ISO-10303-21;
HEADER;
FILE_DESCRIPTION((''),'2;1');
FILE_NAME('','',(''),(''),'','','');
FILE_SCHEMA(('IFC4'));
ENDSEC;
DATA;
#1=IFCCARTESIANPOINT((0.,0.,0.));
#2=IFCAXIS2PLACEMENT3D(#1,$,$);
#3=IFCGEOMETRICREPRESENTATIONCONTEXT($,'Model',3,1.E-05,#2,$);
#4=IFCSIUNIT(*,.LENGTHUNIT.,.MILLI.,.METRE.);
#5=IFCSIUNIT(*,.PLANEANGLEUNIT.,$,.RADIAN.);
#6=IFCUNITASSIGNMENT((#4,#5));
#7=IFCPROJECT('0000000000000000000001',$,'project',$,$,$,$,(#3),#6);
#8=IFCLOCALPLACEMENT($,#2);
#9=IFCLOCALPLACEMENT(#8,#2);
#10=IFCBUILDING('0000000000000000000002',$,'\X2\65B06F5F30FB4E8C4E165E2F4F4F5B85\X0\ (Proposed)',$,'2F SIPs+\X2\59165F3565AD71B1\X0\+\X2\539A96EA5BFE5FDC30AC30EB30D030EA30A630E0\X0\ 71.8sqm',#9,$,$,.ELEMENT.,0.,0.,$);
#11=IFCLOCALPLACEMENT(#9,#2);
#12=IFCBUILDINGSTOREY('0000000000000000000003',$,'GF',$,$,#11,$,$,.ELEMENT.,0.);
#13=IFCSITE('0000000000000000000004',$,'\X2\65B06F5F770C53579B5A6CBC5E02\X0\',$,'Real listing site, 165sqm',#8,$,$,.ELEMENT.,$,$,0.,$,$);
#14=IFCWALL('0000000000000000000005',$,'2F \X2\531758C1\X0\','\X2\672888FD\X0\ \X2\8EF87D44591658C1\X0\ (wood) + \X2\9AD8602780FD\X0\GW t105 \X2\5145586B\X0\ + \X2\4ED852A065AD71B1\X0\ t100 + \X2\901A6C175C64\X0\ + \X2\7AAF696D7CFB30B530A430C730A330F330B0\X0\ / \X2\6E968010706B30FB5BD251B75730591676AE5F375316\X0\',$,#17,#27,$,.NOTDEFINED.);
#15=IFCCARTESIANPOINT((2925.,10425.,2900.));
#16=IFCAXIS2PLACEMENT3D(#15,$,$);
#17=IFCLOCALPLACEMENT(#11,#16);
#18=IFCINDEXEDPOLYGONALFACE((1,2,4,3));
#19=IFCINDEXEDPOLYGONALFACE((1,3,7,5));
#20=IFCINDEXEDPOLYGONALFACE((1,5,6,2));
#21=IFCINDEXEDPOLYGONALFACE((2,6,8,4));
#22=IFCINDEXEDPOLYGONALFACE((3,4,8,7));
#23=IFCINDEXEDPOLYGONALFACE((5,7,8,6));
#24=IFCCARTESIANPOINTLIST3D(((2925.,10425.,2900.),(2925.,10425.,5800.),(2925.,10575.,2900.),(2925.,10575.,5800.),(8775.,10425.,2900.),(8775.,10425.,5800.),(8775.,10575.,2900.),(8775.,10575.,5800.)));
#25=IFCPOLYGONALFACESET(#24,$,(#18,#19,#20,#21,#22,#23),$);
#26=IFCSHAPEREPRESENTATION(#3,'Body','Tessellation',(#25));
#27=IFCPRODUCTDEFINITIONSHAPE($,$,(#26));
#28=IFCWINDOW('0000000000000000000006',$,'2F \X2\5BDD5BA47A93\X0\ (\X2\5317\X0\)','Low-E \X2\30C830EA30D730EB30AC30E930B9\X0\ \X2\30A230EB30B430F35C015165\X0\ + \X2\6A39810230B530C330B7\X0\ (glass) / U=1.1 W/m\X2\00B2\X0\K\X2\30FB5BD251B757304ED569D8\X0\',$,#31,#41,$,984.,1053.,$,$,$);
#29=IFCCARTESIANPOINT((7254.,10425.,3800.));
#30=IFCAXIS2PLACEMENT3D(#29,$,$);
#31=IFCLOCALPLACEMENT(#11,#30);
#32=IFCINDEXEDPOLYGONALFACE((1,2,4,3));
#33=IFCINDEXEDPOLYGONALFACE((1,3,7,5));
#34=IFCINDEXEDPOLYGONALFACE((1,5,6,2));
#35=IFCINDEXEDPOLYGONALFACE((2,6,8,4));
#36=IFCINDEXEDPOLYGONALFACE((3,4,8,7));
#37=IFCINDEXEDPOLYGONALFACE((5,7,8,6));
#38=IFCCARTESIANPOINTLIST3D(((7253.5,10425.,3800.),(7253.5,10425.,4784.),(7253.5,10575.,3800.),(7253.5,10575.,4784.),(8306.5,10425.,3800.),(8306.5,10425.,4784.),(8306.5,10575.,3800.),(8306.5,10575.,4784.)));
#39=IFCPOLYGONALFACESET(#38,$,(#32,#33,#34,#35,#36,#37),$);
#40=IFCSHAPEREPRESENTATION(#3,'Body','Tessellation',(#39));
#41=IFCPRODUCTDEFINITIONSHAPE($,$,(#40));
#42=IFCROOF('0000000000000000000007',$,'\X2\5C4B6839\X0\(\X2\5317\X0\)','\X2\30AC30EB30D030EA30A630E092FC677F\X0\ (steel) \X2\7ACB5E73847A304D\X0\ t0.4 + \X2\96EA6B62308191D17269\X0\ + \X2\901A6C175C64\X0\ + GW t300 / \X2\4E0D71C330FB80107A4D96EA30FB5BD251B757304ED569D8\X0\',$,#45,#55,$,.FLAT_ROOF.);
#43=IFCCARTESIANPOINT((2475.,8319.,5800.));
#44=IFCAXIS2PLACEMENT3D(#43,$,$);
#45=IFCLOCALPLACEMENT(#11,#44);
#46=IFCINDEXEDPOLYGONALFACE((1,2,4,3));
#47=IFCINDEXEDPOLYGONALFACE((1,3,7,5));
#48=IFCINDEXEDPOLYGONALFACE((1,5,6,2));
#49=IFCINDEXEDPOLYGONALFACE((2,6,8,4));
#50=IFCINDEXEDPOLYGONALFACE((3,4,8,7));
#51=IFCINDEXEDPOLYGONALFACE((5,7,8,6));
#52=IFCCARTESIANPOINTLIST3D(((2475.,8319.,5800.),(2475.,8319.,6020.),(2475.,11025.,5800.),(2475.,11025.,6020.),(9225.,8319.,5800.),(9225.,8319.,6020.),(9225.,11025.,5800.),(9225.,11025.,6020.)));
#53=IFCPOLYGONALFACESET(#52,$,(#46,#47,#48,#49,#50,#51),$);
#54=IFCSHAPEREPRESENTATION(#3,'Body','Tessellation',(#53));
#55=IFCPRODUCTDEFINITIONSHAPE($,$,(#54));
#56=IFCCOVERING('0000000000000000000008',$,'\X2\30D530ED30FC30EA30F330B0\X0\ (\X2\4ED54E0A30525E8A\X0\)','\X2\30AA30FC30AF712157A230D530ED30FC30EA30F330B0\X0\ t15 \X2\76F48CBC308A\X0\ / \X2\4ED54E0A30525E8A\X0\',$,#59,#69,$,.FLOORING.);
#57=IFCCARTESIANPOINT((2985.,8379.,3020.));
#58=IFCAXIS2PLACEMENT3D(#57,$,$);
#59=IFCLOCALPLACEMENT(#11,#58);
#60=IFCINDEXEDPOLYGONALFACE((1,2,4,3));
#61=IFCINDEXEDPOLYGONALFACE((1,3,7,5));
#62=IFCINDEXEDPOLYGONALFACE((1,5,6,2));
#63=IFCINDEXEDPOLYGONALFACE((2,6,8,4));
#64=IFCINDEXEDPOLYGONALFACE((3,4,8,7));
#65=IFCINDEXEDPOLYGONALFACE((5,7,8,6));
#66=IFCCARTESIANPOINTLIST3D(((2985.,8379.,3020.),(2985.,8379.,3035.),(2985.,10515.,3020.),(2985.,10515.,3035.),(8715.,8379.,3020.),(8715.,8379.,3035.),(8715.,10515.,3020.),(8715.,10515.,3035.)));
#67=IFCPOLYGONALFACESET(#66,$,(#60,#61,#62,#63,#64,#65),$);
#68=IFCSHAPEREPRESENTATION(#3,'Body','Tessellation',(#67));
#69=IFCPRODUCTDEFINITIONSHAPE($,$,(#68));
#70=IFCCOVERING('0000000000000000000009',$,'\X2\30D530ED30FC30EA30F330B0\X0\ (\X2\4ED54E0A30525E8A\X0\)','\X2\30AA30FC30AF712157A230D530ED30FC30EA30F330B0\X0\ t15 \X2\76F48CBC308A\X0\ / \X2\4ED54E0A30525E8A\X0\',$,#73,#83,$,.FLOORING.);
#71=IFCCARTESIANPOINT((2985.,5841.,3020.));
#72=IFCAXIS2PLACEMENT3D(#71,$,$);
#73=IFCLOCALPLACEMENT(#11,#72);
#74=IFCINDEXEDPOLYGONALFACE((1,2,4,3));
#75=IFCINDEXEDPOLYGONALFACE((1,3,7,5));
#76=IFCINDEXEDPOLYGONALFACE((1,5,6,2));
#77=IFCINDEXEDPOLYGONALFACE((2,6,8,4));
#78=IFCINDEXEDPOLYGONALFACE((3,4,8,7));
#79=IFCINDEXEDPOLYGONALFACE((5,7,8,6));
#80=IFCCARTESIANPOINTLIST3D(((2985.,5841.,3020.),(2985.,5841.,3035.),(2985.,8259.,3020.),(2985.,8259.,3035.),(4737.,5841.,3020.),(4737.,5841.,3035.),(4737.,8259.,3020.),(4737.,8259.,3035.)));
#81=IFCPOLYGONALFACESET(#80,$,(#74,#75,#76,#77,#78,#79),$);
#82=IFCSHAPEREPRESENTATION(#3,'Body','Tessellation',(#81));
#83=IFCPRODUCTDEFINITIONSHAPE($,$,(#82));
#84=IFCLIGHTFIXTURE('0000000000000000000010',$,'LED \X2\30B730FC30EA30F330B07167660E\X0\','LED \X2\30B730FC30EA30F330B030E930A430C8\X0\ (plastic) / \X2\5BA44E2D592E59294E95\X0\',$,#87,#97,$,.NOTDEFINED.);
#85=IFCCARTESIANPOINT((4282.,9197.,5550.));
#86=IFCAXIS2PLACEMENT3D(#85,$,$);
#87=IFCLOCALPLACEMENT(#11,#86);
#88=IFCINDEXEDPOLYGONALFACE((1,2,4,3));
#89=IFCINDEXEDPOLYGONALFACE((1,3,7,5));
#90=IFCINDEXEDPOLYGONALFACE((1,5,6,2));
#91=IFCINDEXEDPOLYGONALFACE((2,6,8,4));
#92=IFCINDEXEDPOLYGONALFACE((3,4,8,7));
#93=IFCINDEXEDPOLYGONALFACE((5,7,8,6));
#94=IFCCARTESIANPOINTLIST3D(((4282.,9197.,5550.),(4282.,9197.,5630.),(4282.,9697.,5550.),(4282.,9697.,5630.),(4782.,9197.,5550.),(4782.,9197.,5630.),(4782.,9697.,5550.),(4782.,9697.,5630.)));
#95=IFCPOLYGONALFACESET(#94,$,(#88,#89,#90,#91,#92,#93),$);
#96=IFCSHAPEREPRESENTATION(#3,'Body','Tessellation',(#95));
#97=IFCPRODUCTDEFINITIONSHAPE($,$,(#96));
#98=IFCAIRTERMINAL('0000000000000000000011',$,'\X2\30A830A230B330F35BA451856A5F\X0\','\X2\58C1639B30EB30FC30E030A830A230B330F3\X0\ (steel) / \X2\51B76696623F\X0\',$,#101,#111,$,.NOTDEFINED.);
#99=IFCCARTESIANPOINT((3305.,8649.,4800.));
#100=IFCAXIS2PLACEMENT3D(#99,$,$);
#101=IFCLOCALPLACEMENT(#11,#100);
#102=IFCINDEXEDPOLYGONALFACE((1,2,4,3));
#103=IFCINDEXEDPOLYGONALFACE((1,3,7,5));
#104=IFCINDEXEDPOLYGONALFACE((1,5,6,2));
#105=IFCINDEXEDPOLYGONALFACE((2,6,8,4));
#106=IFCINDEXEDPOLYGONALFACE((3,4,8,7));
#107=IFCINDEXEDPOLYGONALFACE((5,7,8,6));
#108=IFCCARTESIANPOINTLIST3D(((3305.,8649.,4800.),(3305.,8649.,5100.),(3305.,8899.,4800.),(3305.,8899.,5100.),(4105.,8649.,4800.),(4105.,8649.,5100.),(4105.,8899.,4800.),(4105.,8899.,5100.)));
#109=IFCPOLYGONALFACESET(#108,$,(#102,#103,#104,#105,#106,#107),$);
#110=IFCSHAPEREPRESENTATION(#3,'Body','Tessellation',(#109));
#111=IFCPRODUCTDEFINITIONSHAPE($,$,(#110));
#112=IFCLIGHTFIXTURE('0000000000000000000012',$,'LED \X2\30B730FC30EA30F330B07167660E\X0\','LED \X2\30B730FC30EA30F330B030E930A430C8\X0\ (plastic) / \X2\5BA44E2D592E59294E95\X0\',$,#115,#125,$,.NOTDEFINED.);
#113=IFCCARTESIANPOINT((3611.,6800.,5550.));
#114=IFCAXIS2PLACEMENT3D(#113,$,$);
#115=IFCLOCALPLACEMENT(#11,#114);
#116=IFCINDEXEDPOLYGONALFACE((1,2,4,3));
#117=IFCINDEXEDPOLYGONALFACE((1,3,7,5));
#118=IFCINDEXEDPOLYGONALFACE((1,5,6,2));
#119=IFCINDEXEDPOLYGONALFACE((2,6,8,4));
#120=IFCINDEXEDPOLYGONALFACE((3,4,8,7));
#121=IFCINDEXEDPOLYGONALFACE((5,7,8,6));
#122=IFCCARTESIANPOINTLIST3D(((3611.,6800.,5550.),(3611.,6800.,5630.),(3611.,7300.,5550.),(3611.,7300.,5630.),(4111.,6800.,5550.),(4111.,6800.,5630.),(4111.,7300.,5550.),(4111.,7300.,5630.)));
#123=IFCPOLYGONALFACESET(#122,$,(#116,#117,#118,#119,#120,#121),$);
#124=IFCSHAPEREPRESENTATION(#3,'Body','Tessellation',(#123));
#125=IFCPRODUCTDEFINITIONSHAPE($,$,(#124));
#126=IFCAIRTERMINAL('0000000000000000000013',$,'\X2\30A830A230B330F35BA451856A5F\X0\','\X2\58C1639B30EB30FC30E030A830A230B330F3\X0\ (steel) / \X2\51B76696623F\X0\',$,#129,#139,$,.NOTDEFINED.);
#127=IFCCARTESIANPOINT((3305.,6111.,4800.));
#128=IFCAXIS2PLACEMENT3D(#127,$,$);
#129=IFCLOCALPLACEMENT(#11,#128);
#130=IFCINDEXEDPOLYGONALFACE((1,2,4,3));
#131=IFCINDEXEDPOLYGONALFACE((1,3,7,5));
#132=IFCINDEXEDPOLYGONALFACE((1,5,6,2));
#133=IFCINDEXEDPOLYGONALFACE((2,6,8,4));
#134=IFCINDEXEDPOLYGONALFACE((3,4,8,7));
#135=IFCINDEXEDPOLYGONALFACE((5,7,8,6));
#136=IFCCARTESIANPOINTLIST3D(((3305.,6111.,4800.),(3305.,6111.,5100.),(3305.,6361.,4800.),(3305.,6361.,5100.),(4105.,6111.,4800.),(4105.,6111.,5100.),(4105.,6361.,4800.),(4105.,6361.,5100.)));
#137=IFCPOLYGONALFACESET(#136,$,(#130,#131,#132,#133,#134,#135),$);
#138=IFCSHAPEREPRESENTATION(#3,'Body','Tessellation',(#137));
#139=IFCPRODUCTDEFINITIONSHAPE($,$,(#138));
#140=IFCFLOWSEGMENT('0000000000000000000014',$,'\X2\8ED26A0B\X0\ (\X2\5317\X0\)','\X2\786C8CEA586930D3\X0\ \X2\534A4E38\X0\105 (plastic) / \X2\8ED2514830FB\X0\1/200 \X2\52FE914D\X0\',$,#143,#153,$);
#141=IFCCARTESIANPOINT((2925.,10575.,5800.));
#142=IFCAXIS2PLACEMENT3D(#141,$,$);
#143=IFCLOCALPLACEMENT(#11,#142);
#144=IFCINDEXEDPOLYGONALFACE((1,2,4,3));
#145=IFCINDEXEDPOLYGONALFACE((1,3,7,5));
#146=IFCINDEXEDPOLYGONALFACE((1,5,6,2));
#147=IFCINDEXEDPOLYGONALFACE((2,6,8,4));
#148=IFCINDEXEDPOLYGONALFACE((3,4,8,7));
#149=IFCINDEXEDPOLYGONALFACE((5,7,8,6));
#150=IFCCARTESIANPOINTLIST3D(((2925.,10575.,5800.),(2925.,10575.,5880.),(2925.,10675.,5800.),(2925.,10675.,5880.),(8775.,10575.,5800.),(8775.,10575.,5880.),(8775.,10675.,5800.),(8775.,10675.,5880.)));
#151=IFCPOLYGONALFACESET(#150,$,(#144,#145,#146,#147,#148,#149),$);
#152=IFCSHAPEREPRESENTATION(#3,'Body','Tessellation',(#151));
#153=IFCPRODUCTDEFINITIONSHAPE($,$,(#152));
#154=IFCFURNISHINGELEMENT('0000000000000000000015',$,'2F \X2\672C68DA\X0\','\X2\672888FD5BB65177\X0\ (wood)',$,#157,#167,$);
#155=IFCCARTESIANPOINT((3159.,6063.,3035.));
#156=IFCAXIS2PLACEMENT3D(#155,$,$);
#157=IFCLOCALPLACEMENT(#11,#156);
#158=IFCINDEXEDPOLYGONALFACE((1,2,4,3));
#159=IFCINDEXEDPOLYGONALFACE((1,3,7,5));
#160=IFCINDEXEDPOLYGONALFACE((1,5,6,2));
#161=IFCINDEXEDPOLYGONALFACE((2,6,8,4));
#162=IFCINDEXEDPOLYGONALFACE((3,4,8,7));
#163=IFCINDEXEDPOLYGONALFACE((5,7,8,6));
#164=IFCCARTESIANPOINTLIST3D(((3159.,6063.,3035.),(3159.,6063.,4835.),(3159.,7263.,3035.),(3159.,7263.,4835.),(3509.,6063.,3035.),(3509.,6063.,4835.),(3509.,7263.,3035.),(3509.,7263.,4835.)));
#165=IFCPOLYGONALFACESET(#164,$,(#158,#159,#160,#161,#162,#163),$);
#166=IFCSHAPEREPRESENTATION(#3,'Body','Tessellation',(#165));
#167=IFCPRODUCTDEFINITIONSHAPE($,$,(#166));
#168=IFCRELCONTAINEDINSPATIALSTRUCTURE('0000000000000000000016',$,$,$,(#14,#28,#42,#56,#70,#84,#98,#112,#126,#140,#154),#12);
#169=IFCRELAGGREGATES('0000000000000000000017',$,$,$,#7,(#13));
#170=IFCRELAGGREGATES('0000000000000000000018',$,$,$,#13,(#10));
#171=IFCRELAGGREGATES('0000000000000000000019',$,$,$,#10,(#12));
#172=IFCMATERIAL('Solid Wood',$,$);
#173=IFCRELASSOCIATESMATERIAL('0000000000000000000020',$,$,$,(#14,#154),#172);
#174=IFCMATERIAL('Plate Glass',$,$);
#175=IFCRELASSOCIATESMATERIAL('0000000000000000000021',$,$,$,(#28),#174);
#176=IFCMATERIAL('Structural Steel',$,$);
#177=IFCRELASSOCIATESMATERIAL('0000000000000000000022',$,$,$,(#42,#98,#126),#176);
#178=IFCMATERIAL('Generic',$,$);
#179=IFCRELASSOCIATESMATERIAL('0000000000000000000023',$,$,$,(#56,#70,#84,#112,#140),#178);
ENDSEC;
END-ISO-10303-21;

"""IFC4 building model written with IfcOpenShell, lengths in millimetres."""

from ifc_helpers import new_model, si_unit, frame, frame_2d, origin, place, context, project, spatial, rectangle, extrude, material, element, fill, save


model = new_model("IFC4")

# Units and contexts
model_context = context("Model", 3, precision=1e-05, world=origin())
ifc_project = project(units=[si_unit("LENGTHUNIT", "METRE", prefix="MILLI"), si_unit("PLANEANGLEUNIT", "RADIAN")], contexts=[model_context])

# Site, building, storey
site_placement = place(None, origin())
site = spatial("IfcSite", under=ifc_project, at=site_placement, Name="新潟県南魚沼市", ObjectType="Real listing site, 165sqm", CompositionType="ELEMENT", RefElevation=0.0)
building_placement = place(site_placement, origin())
building = spatial("IfcBuilding", under=site, at=building_placement, Name="新潟・二世帯住宅 (Proposed)", ObjectType="2F SIPs+外張断熱+厚雪対応ガルバリウム 71.8sqm", CompositionType="ELEMENT", ElevationOfRefHeight=0.0, ElevationOfTerrain=0.0)
storey_placement = place(building_placement, origin())
storey = spatial("IfcBuildingStorey", under=building, at=storey_placement, Name="GF", CompositionType="ELEMENT", Elevation=0.0)

# Shared definitions
ifc_material_1 = material(Name="Solid Wood")

# Wall, opening, window
wall_placement = place(storey_placement, frame((2925.0, 10425.0, 2900.0)))
wall = element("IfcWall", 1, at=wall_placement, inside=storey, material=ifc_material_1, Name="2F 北壁", Description="木製 軸組外壁 (wood) + 高性能GW t105 充填 + 付加断熱 t100 + 通気層 + 窯業系サイディング / 準耐火・寒冷地外皮強化", PredefinedType="NOTDEFINED", context=model_context, shape_type="SweptSolid", body=[
    extrude(rectangle(XDim=5850.0, YDim=150.0, at=frame_2d((2925.0, 75.0))), frame((2925.0, 10425.0, 2900.0)), (0.0, 0.0, 1.0), 2900.0),
])
opening_placement = place(storey_placement, frame((7254.0, 10425.0, 3800.0)))
opening = element("IfcOpeningElement", 2, at=opening_placement, cuts=wall, PredefinedType="NOTDEFINED", context=model_context, shape_type="SweptSolid", body=[
    extrude(rectangle(XDim=1053.0, YDim=150.0, at=frame_2d((526.0, 75.0))), frame((7254.0, 10425.0, 3800.0)), (0.0, 0.0, 1.0), 984.0),
])
ifc_material_2 = material(Name="Plate Glass")
window_placement = place(storey_placement, frame((7254.0, 10425.0, 3800.0)))
window = element("IfcWindow", 3, at=window_placement, inside=storey, material=ifc_material_2, Name="2F 寝室窓 (北)", Description="Low-E トリプルガラス アルゴン封入 + 樹脂サッシ (glass) / U=1.1 W/m²K・寒冷地仕様", OverallHeight=984.0, OverallWidth=1053.0, context=model_context, shape_type="SweptSolid", body=[
    extrude(rectangle(XDim=1053.0, YDim=150.0, at=frame_2d((526.0, 75.0))), frame((7254.0, 10425.0, 3800.0)), (0.0, 0.0, 1.0), 984.0),
])
fill(opening, window)

# Roof
ifc_material_3 = material(Name="Structural Steel")
for number, where, name in (
    (4, (2475.0, 8319.0, 5800.0), "屋根(北)"),
):
    element("IfcRoof", number, at=place(storey_placement, frame(where)), inside=storey, material=ifc_material_3, Name=name, Description="ガルバリウム鋼板 (steel) 立平葺き t0.4 + 雪止め金物 + 通気層 + GW t300 / 不燃・耐積雪・寒冷地仕様", PredefinedType="FLAT_ROOF", context=model_context, shape_type="SweptSolid", body=[
        extrude(rectangle(XDim=6750.0, YDim=2706.0, at=frame_2d((3375.0, 1353.0))), frame((2475.0, 8319.0, 5800.0)), (0.0, 0.0, 1.0), 220.0),
    ])

# Coverings
ifc_material_4 = material(Name="Generic")
covering_1_placement = place(storey_placement, frame((2985.0, 8379.0, 3020.0)))
element("IfcCovering", 5, at=covering_1_placement, inside=storey, material=ifc_material_4, Name="フローリング (仕上げ床)", Description="オーク無垢フローリング t15 直貼り / 仕上げ床", PredefinedType="FLOORING", context=model_context, shape_type="SweptSolid", body=[
    extrude(rectangle(XDim=5730.0, YDim=2136.0, at=frame_2d((2865.0, 1068.0))), frame((2985.0, 8379.0, 3020.0)), (0.0, 0.0, 1.0), 15.0),
])
covering_2_placement = place(storey_placement, frame((2985.0, 5841.0, 3020.0)))
element("IfcCovering", 6, at=covering_2_placement, inside=storey, material=ifc_material_4, Name="フローリング (仕上げ床)", Description="オーク無垢フローリング t15 直貼り / 仕上げ床", PredefinedType="FLOORING", context=model_context, shape_type="SweptSolid", body=[
    extrude(rectangle(XDim=1752.0, YDim=2418.0, at=frame_2d((876.0, 1209.0))), frame((2985.0, 5841.0, 3020.0)), (0.0, 0.0, 1.0), 15.0),
])

# Light fixture
light_fixture_1_placement = place(storey_placement, frame((4282.0, 9197.0, 5550.0)))
element("IfcLightFixture", 7, at=light_fixture_1_placement, inside=storey, material=ifc_material_4, Name="LED シーリング照明", Description="LED シーリングライト (plastic) / 室中央天井", PredefinedType="NOTDEFINED", context=model_context, shape_type="SweptSolid", body=[
    extrude(rectangle(XDim=500.0, YDim=500.0, at=frame_2d((250.0, 250.0))), frame((4282.0, 9197.0, 5550.0)), (0.0, 0.0, 1.0), 80.0),
])

# Air terminal
air_terminal_1_placement = place(storey_placement, frame((3305.0, 8649.0, 4800.0)))
element("IfcAirTerminal", 8, at=air_terminal_1_placement, inside=storey, material=ifc_material_3, Name="エアコン室内機", Description="壁掛ルームエアコン (steel) / 冷暖房", PredefinedType="NOTDEFINED", context=model_context, shape_type="SweptSolid", body=[
    extrude(rectangle(XDim=800.0, YDim=250.0, at=frame_2d((400.0, 125.0))), frame((3305.0, 8649.0, 4800.0)), (0.0, 0.0, 1.0), 300.0),
])

# Light fixture
light_fixture_2_placement = place(storey_placement, frame((3611.0, 6800.0, 5550.0)))
element("IfcLightFixture", 9, at=light_fixture_2_placement, inside=storey, material=ifc_material_4, Name="LED シーリング照明", Description="LED シーリングライト (plastic) / 室中央天井", PredefinedType="NOTDEFINED", context=model_context, shape_type="SweptSolid", body=[
    extrude(rectangle(XDim=500.0, YDim=500.0, at=frame_2d((250.0, 250.0))), frame((3611.0, 6800.0, 5550.0)), (0.0, 0.0, 1.0), 80.0),
])

# Air terminal
air_terminal_2_placement = place(storey_placement, frame((3305.0, 6111.0, 4800.0)))
element("IfcAirTerminal", 10, at=air_terminal_2_placement, inside=storey, material=ifc_material_3, Name="エアコン室内機", Description="壁掛ルームエアコン (steel) / 冷暖房", PredefinedType="NOTDEFINED", context=model_context, shape_type="SweptSolid", body=[
    extrude(rectangle(XDim=800.0, YDim=250.0, at=frame_2d((400.0, 125.0))), frame((3305.0, 6111.0, 4800.0)), (0.0, 0.0, 1.0), 300.0),
])

# Flow segment
flow_segment_placement = place(storey_placement, frame((2925.0, 10575.0, 5800.0)))
element("IfcFlowSegment", 11, at=flow_segment_placement, inside=storey, material=ifc_material_4, Name="軒樋 (北)", Description="硬質塩ビ 半丸105 (plastic) / 軒先・1/200 勾配", context=model_context, shape_type="SweptSolid", body=[
    extrude(rectangle(XDim=5850.0, YDim=100.0, at=frame_2d((2925.0, 50.0))), frame((2925.0, 10575.0, 5800.0)), (0.0, 0.0, 1.0), 80.0),
])

# Furnishing element
furnishing_placement = place(storey_placement, frame((3159.0, 6063.0, 3035.0)))
element("IfcFurnishingElement", 12, at=furnishing_placement, inside=storey, material=ifc_material_1, Name="2F 本棚", Description="木製家具 (wood)", context=model_context, shape_type="SweptSolid", body=[
    extrude(rectangle(XDim=350.0, YDim=1200.0, at=frame_2d((175.0, 600.0))), frame((3159.0, 6063.0, 3035.0)), (0.0, 0.0, 1.0), 1800.0),
])

save(model, "model.ifc")
